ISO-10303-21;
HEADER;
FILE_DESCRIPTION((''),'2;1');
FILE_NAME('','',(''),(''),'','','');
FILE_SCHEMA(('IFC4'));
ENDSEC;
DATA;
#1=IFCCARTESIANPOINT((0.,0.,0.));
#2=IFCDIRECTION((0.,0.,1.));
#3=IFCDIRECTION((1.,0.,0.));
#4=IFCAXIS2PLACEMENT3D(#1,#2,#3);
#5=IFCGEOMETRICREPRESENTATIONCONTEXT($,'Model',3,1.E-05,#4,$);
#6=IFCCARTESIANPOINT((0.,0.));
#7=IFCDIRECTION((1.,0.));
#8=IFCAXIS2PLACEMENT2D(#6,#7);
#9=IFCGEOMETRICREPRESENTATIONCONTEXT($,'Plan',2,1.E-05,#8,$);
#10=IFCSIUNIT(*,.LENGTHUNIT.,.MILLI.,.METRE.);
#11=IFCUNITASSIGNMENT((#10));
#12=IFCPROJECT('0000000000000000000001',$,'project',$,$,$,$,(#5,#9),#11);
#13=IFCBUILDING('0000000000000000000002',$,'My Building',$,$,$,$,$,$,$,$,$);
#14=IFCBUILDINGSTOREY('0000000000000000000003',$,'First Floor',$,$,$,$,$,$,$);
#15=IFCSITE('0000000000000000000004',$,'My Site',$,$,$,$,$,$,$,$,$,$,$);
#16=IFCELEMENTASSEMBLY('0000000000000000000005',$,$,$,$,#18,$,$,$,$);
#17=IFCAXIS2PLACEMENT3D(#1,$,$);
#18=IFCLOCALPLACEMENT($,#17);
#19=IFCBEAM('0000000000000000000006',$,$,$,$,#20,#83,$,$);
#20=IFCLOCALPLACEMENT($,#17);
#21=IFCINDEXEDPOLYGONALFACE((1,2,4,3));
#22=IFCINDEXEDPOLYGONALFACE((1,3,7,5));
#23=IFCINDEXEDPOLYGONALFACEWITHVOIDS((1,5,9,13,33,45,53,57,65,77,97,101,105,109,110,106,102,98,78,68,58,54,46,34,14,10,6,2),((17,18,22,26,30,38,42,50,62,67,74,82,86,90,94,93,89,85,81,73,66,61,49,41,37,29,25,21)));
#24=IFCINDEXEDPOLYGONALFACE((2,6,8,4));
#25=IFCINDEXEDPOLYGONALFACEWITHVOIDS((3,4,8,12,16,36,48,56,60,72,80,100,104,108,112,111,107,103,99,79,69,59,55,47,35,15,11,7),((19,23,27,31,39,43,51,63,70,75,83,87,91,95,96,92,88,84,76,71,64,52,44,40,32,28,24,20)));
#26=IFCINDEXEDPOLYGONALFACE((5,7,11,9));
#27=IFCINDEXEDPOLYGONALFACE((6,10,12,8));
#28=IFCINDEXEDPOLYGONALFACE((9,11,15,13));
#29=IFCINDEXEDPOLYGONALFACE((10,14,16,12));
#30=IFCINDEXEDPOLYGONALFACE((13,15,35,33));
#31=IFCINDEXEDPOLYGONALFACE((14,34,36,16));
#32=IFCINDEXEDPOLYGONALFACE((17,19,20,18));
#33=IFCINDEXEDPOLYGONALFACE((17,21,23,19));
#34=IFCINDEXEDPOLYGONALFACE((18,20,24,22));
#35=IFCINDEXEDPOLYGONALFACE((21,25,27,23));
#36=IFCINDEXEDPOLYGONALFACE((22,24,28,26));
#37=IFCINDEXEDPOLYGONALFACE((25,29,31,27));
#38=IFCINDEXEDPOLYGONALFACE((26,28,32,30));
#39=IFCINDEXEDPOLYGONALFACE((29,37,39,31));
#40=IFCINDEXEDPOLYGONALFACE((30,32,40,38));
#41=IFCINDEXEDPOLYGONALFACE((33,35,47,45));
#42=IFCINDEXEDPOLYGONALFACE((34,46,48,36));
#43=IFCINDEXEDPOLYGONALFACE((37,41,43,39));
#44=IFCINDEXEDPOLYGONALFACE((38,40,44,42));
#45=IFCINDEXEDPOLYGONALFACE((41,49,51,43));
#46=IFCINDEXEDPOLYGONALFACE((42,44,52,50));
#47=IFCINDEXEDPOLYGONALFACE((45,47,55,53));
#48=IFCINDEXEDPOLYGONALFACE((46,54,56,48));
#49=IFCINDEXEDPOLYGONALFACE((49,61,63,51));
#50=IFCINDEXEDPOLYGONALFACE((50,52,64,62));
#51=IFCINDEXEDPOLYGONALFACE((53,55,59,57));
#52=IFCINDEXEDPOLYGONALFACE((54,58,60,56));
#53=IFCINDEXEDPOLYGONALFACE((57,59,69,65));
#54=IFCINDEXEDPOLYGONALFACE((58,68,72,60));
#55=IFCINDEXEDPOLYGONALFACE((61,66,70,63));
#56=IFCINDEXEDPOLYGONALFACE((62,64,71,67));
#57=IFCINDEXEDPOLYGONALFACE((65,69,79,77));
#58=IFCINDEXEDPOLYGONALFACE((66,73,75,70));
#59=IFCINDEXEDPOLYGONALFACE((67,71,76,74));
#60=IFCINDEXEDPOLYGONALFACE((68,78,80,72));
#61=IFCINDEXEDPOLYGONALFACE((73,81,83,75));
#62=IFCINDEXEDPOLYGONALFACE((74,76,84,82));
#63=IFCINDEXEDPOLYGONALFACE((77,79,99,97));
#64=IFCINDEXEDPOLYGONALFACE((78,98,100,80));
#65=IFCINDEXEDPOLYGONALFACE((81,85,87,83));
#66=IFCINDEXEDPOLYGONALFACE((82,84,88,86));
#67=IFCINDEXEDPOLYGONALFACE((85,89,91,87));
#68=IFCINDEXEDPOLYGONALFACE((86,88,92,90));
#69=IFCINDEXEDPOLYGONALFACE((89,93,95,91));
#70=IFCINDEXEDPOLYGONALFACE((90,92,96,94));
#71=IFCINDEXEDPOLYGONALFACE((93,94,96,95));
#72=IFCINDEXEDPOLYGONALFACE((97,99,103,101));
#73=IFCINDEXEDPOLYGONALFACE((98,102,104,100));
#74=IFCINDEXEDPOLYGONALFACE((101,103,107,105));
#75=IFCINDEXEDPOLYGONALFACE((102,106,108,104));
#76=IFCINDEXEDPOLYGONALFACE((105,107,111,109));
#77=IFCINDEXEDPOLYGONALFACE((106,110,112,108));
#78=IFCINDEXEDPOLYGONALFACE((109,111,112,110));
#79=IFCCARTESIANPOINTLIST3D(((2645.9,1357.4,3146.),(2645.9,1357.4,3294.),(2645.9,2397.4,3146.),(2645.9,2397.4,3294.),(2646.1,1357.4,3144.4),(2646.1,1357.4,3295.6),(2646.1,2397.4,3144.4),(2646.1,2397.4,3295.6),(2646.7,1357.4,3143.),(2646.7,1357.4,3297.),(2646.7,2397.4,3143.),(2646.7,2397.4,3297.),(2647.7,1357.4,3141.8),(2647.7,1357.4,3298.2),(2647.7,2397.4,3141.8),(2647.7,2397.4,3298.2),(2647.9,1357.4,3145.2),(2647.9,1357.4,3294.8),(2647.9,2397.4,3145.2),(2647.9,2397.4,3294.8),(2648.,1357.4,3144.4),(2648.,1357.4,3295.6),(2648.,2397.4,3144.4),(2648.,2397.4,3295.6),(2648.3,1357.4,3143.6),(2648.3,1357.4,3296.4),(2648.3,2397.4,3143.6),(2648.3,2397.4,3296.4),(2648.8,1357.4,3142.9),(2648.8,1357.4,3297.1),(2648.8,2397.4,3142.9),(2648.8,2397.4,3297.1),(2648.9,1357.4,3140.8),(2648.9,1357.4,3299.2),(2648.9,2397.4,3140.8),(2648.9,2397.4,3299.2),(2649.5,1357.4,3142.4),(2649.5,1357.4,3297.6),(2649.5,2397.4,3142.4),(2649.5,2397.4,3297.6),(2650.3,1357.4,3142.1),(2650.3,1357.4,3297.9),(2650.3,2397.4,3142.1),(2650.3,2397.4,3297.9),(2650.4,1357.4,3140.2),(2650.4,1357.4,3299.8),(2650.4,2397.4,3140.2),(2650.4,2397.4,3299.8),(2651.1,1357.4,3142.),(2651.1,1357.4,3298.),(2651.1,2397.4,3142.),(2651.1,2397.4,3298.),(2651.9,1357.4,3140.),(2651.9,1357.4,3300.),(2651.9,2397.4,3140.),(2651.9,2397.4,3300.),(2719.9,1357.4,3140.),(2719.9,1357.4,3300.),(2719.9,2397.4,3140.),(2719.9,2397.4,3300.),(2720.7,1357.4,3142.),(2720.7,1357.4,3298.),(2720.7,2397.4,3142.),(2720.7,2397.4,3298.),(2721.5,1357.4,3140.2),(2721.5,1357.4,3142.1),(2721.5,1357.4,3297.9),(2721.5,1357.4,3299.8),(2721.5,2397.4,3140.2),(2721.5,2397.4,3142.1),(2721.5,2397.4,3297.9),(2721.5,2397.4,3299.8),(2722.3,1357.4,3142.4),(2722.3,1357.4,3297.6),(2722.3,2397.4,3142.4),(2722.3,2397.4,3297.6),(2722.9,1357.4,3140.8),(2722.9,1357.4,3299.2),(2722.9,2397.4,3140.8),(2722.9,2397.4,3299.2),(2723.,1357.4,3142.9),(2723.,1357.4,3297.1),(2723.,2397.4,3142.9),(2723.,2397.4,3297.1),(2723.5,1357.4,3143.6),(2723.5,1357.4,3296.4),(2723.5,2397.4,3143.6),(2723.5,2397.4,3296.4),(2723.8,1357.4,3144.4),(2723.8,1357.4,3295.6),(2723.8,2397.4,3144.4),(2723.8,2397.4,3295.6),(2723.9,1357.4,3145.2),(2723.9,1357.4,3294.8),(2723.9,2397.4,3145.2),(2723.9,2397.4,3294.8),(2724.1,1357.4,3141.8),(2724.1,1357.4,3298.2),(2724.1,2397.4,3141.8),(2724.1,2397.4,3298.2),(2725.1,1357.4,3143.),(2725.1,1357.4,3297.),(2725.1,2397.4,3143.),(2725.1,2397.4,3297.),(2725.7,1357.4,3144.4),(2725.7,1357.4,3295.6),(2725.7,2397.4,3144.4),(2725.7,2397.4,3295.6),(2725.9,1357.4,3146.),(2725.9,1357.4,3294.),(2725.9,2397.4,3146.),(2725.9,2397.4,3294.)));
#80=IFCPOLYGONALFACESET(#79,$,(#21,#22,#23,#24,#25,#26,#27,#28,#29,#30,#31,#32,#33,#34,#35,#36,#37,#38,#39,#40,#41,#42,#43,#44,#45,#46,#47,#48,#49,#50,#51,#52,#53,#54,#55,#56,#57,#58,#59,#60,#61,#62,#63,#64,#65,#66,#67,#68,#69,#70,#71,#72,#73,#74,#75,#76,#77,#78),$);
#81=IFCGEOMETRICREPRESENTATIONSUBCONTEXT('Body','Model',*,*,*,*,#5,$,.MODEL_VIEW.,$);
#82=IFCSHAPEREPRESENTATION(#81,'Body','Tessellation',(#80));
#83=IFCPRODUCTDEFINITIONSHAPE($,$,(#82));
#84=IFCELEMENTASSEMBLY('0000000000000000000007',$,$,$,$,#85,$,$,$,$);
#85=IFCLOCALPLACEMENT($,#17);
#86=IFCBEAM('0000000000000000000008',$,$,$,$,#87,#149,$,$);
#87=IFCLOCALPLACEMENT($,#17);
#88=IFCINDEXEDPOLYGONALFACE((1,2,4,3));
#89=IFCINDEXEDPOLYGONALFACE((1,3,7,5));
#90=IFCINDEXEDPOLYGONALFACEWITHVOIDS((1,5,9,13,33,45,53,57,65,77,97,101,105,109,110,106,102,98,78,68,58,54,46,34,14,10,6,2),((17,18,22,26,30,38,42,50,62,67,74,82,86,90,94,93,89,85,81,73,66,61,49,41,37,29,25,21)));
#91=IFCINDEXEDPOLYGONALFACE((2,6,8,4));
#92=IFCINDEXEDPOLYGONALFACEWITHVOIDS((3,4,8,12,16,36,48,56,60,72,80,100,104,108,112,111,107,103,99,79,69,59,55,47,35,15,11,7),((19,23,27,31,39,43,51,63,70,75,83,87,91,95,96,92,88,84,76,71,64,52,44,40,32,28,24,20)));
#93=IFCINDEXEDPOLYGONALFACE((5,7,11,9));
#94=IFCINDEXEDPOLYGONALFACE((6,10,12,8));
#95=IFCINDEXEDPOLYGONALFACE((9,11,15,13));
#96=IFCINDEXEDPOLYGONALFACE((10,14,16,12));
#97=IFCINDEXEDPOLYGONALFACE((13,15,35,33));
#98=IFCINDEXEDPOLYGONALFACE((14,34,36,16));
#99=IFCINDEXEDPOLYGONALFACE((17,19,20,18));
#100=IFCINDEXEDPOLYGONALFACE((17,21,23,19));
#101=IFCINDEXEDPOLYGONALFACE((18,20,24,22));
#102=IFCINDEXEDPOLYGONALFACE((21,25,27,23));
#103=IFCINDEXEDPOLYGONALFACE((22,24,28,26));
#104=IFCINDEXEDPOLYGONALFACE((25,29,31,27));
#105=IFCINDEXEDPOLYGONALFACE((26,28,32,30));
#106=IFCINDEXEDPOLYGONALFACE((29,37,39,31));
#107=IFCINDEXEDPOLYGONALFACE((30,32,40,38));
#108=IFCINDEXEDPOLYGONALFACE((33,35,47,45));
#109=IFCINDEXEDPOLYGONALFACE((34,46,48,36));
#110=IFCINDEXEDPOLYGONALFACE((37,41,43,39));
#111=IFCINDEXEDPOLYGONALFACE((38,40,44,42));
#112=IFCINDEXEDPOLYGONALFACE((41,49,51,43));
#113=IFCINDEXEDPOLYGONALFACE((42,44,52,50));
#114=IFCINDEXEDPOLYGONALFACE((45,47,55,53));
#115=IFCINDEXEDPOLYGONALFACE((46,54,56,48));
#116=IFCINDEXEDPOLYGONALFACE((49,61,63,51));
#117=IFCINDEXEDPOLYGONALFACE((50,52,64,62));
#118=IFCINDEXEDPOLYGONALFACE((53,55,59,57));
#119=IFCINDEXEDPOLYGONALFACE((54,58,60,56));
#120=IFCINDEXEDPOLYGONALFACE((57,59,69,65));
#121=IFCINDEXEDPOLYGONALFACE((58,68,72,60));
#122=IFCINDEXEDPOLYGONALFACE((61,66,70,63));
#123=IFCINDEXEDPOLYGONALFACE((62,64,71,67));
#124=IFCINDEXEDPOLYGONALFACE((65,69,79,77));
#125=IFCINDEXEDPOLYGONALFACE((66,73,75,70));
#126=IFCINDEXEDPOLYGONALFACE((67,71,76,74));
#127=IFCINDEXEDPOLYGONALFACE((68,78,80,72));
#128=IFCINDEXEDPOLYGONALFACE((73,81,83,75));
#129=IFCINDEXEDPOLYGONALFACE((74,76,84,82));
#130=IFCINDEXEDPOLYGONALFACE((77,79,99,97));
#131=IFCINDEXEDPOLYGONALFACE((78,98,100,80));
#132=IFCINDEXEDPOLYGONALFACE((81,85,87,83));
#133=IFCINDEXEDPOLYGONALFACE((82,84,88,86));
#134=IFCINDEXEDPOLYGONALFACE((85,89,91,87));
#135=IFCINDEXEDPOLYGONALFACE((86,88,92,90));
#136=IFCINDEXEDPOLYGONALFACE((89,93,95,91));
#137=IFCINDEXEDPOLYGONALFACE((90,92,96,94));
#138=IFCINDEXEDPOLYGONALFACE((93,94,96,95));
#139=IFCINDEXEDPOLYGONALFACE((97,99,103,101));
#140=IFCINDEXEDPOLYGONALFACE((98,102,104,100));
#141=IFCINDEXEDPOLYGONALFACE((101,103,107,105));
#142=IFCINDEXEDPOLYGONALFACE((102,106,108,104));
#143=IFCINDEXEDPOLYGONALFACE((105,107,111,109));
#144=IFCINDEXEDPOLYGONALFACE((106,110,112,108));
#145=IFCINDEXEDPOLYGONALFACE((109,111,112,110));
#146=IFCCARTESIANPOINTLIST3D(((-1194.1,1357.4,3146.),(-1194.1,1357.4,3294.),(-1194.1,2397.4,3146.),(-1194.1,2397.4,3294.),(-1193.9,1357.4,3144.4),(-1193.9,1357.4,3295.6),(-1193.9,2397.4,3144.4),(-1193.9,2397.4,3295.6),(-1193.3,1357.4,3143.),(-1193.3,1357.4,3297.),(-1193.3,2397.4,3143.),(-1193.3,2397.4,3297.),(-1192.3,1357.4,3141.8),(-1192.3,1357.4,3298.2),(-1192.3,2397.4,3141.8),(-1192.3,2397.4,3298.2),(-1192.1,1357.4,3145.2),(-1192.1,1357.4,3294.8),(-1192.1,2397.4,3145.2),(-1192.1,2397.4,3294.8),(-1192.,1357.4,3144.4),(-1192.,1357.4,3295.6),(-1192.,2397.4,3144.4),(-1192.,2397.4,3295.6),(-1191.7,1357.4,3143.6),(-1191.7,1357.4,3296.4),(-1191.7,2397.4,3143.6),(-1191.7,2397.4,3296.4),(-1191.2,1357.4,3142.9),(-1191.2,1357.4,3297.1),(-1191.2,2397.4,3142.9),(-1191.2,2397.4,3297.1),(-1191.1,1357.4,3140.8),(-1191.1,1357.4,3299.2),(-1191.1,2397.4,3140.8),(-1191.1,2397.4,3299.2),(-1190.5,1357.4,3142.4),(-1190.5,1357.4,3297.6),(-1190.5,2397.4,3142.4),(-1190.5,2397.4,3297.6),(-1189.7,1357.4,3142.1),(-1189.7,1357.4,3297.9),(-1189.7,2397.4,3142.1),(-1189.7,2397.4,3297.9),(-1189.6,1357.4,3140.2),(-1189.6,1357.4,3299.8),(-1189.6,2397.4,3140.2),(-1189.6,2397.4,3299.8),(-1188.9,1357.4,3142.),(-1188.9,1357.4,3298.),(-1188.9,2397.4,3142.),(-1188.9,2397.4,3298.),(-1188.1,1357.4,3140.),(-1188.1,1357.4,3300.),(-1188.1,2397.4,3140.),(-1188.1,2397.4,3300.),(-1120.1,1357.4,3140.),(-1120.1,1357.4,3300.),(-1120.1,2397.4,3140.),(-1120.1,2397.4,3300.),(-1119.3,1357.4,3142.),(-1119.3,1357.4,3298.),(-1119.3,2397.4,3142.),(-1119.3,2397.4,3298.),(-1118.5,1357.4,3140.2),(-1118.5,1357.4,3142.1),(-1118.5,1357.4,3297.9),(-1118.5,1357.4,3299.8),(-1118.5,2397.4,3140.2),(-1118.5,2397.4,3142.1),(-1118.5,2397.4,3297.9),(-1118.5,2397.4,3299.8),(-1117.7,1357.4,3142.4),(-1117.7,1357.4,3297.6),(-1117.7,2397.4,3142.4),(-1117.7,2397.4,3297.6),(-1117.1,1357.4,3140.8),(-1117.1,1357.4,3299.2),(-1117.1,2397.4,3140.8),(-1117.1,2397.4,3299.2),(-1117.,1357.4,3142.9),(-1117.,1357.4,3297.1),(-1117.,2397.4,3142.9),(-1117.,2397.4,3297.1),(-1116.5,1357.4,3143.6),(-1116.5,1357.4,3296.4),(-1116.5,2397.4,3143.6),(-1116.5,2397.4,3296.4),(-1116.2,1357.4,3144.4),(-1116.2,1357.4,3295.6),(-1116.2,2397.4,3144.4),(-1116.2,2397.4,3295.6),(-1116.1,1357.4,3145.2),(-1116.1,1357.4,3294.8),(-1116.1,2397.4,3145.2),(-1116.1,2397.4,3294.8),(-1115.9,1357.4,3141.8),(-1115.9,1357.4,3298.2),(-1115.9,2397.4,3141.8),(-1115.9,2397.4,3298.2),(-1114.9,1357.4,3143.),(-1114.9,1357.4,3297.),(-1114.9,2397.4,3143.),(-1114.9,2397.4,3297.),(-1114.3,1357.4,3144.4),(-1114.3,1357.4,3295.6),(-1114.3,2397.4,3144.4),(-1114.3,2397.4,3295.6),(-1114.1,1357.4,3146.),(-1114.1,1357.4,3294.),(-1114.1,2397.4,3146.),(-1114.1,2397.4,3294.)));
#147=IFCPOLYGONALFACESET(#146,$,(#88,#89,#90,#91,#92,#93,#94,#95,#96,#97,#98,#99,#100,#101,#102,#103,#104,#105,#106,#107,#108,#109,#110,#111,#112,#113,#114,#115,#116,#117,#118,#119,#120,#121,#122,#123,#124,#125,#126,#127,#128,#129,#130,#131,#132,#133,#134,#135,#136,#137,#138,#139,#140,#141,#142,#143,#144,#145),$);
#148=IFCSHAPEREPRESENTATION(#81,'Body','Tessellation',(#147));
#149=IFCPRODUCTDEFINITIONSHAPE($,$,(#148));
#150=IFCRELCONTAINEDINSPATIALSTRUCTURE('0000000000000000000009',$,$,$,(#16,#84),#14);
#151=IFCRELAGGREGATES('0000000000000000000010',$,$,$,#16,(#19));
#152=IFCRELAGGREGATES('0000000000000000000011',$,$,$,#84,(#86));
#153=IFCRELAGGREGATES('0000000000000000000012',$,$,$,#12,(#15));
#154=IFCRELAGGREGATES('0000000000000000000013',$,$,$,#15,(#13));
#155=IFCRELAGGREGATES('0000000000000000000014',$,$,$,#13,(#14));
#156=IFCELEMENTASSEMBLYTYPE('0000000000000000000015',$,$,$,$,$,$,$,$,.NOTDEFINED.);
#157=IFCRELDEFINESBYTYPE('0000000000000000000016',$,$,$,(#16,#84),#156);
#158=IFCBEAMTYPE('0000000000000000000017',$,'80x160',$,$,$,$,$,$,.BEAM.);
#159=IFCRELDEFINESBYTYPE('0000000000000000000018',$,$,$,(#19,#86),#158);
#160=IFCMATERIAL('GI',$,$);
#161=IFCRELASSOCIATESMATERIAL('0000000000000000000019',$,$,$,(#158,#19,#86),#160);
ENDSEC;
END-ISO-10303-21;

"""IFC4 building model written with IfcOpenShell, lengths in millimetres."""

from ifc_helpers import new_model, si_unit, frame, origin_with_axes, origin_2d_with_axis, place, context, subcontext, project, spatial, hollow_rectangle, extrude, material, material_profile, profile_set, profile_usage, type_object, element, aggregate, save


model = new_model("IFC4")

# Units and contexts
model_context = context("Model", 3, precision=1e-05, world=origin_with_axes())
plan_context = context("Plan", 2, precision=1e-05, world=origin_2d_with_axis())
body_context = subcontext(model_context, "Body", "Model", "MODEL_VIEW")
ifc_project = project(units=[si_unit("LENGTHUNIT", "METRE", prefix="MILLI")], contexts=[model_context, plan_context])

# Site, building, storey
site = spatial("IfcSite", under=ifc_project, Name="My Site")
building = spatial("IfcBuilding", under=site, Name="My Building")
storey = spatial("IfcBuildingStorey", under=building, Name="First Floor")

# Element assemblies, beams
element_assembly_type = type_object("IfcElementAssemblyType", PredefinedType="NOTDEFINED")
ifc_material = material(Name="GI")
ifc_material_profile = material_profile(ifc_material, hollow_rectangle(XDim=80.0, YDim=160.0, WallThickness=2.0, InnerFilletRadius=3.2, OuterFilletRadius=6.0))
ifc_profile_set = profile_set([ifc_material_profile], Name="80x160 GI Rectangular Hollow")
beam_type = type_object("IfcBeamType", Name="80x160", PredefinedType="BEAM", material=ifc_profile_set)
assembly_1_placement = place(None, frame((2685.9, 1277.4, 3220.0), z_axis=(0.0, 1.0, 0.0), x_axis=(1.0, 0.0, 0.0)))
assembly_1 = element("IfcElementAssembly", 1, at=assembly_1_placement, inside=storey, type_object=element_assembly_type)
ifc_profile_usage_1 = profile_usage(ifc_profile_set)
beam_1_placement = place(assembly_1_placement, frame((0.0, 0.0, 80.0), z_axis=(0.0, 0.0, 1.0), x_axis=(1.0, 0.0, 0.0)))
beam_1 = element("IfcBeam", 2, at=beam_1_placement, type_object=beam_type, material=ifc_profile_usage_1, context=body_context, shape_type="SweptSolid", body=[
    extrude(hollow_rectangle(XDim=80.0, YDim=160.0, WallThickness=2.0, InnerFilletRadius=3.2, OuterFilletRadius=6.0), origin_with_axes(), (0.0, 0.0, 1.0), 1040.0),
])
aggregate(assembly_1, [beam_1])
assembly_2_placement = place(None, frame((-1154.1, 1277.4, 3220.0), z_axis=(0.0, 1.0, 0.0), x_axis=(1.0, 0.0, 0.0)))
assembly_2 = element("IfcElementAssembly", 3, at=assembly_2_placement, inside=storey, type_object=element_assembly_type)
ifc_profile_usage_2 = profile_usage(ifc_profile_set)
beam_2_placement = place(assembly_2_placement, frame((0.0, 0.0, 80.0), z_axis=(0.0, 0.0, 1.0), x_axis=(1.0, 0.0, 0.0)))
beam_2 = element("IfcBeam", 4, at=beam_2_placement, type_object=beam_type, material=ifc_profile_usage_2, context=body_context, shape_type="SweptSolid", body=[
    extrude(hollow_rectangle(XDim=80.0, YDim=160.0, WallThickness=2.0, InnerFilletRadius=3.2, OuterFilletRadius=6.0), origin_with_axes(), (0.0, 0.0, 1.0), 1040.0),
])
aggregate(assembly_2, [beam_2])

save(model, "model.ifc")
